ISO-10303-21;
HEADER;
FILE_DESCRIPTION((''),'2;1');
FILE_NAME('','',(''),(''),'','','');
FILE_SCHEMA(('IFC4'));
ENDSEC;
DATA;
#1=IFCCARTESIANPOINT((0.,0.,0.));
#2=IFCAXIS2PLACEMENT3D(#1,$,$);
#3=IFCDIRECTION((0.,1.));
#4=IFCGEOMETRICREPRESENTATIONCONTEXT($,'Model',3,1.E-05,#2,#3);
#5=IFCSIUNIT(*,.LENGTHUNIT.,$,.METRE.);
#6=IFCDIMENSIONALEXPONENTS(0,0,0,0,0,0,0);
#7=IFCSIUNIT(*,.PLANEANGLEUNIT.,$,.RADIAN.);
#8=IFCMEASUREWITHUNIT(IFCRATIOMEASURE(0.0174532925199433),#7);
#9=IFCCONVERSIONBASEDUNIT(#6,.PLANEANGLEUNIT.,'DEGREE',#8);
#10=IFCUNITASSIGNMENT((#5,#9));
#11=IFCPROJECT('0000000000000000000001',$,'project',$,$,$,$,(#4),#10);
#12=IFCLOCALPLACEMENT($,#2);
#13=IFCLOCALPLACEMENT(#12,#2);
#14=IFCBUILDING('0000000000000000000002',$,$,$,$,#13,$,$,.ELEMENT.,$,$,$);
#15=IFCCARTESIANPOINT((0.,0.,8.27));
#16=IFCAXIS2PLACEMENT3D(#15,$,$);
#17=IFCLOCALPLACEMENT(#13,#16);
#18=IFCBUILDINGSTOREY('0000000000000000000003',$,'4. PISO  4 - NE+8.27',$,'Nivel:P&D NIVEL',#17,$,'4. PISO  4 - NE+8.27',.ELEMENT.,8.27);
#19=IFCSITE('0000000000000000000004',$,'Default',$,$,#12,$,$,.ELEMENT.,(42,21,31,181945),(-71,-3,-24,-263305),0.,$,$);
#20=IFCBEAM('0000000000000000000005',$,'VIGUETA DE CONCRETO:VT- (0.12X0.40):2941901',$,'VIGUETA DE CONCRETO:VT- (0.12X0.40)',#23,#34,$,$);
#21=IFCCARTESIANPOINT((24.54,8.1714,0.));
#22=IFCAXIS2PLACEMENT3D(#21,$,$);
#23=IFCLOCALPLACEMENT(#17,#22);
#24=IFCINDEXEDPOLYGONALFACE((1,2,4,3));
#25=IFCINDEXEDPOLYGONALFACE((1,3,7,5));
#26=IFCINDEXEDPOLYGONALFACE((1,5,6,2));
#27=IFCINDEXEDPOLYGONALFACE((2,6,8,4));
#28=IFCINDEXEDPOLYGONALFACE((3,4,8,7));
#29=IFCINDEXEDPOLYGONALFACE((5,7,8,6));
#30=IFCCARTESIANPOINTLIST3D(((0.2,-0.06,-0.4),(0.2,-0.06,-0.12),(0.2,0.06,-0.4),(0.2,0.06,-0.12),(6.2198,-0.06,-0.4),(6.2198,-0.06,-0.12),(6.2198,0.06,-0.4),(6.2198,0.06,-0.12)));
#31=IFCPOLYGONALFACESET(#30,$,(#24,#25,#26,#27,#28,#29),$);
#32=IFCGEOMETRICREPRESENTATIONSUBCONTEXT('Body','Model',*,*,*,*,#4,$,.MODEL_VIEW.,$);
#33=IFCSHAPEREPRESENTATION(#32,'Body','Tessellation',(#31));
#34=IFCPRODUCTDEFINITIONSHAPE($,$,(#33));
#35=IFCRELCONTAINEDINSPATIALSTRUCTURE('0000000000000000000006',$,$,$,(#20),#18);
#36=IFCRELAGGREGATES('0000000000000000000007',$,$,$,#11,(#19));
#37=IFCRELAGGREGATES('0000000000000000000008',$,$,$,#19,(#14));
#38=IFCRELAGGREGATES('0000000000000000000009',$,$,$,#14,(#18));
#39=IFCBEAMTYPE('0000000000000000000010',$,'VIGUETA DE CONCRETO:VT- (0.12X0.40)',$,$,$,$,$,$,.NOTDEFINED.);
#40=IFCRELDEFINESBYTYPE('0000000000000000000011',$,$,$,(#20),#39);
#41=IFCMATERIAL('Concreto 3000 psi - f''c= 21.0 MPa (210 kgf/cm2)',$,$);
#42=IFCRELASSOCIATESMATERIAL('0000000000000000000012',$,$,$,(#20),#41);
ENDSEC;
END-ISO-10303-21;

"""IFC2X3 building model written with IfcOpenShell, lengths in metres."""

from ifc_helpers import new_model, entity, si_unit, converted_unit, direction, frame, frame_2d, origin, place, context, subcontext, project, spatial, rectangle, extrude, material, type_object, element, save


model = new_model("IFC2X3")

# Units and contexts
model_context = context("Model", 3, precision=1e-05, world=origin(), true_north=direction((0.0, 1.0)))
body_context = subcontext(model_context, "Body", "Model", "MODEL_VIEW")
ifc_project = project(units=[si_unit("LENGTHUNIT", "METRE"), converted_unit("PLANEANGLEUNIT", "DEGREE", entity("IfcRatioMeasure", 0.0174532925199433), si_unit("PLANEANGLEUNIT", "RADIAN"), dimensions=[0, 0, 0, 0, 0, 0, 0])], contexts=[model_context])

# Site, building, storey
site_placement = place(None, origin())
site = spatial("IfcSite", under=ifc_project, at=site_placement, Name="Default", CompositionType="ELEMENT", RefLatitude=(42, 21, 31, 181945), RefLongitude=(-71, -3, -24, -263305), RefElevation=0.0)
building_placement = place(site_placement, origin())
building = spatial("IfcBuilding", under=site, at=building_placement, CompositionType="ELEMENT")
storey_placement = place(building_placement, frame((0.0, 0.0, 8.27)))
storey = spatial("IfcBuildingStorey", under=building, at=storey_placement, Name="4. PISO  4 - NE+8.27", ObjectType="Nivel:P&D NIVEL", LongName="4. PISO  4 - NE+8.27", CompositionType="ELEMENT", Elevation=8.27)

# Beam
ifc_material = material(Name="Concreto 3000 psi - f'c= 21.0 MPa (210 kgf/cm2)")
beam_type_1 = type_object("IfcBeamType", Name="VIGUETA DE CONCRETO:VT- (0.12X0.40)", PredefinedType="NOTDEFINED")
beam_1_placement = place(storey_placement, frame((24.54, 8.1714, 0.0)))
element("IfcBeam", 1, at=beam_1_placement, inside=storey, type_object=beam_type_1, material=ifc_material, Name="VIGUETA DE CONCRETO:VT- (0.12X0.40):2941901", ObjectType="VIGUETA DE CONCRETO:VT- (0.12X0.40)", context=body_context, shape_type="SweptSolid", body=[
    extrude(rectangle(XDim=0.28, YDim=0.12, at=frame_2d((0.0, 0.0), x_axis=(1.0, 0.0))), frame((0.2, 0.0, -0.26), z_axis=(1.0, 0.0, 0.0), x_axis=(0.0, 0.0, -1.0)), (0.0, 0.0, 1.0), 6.0198),
])

save(model, "model.ifc")
